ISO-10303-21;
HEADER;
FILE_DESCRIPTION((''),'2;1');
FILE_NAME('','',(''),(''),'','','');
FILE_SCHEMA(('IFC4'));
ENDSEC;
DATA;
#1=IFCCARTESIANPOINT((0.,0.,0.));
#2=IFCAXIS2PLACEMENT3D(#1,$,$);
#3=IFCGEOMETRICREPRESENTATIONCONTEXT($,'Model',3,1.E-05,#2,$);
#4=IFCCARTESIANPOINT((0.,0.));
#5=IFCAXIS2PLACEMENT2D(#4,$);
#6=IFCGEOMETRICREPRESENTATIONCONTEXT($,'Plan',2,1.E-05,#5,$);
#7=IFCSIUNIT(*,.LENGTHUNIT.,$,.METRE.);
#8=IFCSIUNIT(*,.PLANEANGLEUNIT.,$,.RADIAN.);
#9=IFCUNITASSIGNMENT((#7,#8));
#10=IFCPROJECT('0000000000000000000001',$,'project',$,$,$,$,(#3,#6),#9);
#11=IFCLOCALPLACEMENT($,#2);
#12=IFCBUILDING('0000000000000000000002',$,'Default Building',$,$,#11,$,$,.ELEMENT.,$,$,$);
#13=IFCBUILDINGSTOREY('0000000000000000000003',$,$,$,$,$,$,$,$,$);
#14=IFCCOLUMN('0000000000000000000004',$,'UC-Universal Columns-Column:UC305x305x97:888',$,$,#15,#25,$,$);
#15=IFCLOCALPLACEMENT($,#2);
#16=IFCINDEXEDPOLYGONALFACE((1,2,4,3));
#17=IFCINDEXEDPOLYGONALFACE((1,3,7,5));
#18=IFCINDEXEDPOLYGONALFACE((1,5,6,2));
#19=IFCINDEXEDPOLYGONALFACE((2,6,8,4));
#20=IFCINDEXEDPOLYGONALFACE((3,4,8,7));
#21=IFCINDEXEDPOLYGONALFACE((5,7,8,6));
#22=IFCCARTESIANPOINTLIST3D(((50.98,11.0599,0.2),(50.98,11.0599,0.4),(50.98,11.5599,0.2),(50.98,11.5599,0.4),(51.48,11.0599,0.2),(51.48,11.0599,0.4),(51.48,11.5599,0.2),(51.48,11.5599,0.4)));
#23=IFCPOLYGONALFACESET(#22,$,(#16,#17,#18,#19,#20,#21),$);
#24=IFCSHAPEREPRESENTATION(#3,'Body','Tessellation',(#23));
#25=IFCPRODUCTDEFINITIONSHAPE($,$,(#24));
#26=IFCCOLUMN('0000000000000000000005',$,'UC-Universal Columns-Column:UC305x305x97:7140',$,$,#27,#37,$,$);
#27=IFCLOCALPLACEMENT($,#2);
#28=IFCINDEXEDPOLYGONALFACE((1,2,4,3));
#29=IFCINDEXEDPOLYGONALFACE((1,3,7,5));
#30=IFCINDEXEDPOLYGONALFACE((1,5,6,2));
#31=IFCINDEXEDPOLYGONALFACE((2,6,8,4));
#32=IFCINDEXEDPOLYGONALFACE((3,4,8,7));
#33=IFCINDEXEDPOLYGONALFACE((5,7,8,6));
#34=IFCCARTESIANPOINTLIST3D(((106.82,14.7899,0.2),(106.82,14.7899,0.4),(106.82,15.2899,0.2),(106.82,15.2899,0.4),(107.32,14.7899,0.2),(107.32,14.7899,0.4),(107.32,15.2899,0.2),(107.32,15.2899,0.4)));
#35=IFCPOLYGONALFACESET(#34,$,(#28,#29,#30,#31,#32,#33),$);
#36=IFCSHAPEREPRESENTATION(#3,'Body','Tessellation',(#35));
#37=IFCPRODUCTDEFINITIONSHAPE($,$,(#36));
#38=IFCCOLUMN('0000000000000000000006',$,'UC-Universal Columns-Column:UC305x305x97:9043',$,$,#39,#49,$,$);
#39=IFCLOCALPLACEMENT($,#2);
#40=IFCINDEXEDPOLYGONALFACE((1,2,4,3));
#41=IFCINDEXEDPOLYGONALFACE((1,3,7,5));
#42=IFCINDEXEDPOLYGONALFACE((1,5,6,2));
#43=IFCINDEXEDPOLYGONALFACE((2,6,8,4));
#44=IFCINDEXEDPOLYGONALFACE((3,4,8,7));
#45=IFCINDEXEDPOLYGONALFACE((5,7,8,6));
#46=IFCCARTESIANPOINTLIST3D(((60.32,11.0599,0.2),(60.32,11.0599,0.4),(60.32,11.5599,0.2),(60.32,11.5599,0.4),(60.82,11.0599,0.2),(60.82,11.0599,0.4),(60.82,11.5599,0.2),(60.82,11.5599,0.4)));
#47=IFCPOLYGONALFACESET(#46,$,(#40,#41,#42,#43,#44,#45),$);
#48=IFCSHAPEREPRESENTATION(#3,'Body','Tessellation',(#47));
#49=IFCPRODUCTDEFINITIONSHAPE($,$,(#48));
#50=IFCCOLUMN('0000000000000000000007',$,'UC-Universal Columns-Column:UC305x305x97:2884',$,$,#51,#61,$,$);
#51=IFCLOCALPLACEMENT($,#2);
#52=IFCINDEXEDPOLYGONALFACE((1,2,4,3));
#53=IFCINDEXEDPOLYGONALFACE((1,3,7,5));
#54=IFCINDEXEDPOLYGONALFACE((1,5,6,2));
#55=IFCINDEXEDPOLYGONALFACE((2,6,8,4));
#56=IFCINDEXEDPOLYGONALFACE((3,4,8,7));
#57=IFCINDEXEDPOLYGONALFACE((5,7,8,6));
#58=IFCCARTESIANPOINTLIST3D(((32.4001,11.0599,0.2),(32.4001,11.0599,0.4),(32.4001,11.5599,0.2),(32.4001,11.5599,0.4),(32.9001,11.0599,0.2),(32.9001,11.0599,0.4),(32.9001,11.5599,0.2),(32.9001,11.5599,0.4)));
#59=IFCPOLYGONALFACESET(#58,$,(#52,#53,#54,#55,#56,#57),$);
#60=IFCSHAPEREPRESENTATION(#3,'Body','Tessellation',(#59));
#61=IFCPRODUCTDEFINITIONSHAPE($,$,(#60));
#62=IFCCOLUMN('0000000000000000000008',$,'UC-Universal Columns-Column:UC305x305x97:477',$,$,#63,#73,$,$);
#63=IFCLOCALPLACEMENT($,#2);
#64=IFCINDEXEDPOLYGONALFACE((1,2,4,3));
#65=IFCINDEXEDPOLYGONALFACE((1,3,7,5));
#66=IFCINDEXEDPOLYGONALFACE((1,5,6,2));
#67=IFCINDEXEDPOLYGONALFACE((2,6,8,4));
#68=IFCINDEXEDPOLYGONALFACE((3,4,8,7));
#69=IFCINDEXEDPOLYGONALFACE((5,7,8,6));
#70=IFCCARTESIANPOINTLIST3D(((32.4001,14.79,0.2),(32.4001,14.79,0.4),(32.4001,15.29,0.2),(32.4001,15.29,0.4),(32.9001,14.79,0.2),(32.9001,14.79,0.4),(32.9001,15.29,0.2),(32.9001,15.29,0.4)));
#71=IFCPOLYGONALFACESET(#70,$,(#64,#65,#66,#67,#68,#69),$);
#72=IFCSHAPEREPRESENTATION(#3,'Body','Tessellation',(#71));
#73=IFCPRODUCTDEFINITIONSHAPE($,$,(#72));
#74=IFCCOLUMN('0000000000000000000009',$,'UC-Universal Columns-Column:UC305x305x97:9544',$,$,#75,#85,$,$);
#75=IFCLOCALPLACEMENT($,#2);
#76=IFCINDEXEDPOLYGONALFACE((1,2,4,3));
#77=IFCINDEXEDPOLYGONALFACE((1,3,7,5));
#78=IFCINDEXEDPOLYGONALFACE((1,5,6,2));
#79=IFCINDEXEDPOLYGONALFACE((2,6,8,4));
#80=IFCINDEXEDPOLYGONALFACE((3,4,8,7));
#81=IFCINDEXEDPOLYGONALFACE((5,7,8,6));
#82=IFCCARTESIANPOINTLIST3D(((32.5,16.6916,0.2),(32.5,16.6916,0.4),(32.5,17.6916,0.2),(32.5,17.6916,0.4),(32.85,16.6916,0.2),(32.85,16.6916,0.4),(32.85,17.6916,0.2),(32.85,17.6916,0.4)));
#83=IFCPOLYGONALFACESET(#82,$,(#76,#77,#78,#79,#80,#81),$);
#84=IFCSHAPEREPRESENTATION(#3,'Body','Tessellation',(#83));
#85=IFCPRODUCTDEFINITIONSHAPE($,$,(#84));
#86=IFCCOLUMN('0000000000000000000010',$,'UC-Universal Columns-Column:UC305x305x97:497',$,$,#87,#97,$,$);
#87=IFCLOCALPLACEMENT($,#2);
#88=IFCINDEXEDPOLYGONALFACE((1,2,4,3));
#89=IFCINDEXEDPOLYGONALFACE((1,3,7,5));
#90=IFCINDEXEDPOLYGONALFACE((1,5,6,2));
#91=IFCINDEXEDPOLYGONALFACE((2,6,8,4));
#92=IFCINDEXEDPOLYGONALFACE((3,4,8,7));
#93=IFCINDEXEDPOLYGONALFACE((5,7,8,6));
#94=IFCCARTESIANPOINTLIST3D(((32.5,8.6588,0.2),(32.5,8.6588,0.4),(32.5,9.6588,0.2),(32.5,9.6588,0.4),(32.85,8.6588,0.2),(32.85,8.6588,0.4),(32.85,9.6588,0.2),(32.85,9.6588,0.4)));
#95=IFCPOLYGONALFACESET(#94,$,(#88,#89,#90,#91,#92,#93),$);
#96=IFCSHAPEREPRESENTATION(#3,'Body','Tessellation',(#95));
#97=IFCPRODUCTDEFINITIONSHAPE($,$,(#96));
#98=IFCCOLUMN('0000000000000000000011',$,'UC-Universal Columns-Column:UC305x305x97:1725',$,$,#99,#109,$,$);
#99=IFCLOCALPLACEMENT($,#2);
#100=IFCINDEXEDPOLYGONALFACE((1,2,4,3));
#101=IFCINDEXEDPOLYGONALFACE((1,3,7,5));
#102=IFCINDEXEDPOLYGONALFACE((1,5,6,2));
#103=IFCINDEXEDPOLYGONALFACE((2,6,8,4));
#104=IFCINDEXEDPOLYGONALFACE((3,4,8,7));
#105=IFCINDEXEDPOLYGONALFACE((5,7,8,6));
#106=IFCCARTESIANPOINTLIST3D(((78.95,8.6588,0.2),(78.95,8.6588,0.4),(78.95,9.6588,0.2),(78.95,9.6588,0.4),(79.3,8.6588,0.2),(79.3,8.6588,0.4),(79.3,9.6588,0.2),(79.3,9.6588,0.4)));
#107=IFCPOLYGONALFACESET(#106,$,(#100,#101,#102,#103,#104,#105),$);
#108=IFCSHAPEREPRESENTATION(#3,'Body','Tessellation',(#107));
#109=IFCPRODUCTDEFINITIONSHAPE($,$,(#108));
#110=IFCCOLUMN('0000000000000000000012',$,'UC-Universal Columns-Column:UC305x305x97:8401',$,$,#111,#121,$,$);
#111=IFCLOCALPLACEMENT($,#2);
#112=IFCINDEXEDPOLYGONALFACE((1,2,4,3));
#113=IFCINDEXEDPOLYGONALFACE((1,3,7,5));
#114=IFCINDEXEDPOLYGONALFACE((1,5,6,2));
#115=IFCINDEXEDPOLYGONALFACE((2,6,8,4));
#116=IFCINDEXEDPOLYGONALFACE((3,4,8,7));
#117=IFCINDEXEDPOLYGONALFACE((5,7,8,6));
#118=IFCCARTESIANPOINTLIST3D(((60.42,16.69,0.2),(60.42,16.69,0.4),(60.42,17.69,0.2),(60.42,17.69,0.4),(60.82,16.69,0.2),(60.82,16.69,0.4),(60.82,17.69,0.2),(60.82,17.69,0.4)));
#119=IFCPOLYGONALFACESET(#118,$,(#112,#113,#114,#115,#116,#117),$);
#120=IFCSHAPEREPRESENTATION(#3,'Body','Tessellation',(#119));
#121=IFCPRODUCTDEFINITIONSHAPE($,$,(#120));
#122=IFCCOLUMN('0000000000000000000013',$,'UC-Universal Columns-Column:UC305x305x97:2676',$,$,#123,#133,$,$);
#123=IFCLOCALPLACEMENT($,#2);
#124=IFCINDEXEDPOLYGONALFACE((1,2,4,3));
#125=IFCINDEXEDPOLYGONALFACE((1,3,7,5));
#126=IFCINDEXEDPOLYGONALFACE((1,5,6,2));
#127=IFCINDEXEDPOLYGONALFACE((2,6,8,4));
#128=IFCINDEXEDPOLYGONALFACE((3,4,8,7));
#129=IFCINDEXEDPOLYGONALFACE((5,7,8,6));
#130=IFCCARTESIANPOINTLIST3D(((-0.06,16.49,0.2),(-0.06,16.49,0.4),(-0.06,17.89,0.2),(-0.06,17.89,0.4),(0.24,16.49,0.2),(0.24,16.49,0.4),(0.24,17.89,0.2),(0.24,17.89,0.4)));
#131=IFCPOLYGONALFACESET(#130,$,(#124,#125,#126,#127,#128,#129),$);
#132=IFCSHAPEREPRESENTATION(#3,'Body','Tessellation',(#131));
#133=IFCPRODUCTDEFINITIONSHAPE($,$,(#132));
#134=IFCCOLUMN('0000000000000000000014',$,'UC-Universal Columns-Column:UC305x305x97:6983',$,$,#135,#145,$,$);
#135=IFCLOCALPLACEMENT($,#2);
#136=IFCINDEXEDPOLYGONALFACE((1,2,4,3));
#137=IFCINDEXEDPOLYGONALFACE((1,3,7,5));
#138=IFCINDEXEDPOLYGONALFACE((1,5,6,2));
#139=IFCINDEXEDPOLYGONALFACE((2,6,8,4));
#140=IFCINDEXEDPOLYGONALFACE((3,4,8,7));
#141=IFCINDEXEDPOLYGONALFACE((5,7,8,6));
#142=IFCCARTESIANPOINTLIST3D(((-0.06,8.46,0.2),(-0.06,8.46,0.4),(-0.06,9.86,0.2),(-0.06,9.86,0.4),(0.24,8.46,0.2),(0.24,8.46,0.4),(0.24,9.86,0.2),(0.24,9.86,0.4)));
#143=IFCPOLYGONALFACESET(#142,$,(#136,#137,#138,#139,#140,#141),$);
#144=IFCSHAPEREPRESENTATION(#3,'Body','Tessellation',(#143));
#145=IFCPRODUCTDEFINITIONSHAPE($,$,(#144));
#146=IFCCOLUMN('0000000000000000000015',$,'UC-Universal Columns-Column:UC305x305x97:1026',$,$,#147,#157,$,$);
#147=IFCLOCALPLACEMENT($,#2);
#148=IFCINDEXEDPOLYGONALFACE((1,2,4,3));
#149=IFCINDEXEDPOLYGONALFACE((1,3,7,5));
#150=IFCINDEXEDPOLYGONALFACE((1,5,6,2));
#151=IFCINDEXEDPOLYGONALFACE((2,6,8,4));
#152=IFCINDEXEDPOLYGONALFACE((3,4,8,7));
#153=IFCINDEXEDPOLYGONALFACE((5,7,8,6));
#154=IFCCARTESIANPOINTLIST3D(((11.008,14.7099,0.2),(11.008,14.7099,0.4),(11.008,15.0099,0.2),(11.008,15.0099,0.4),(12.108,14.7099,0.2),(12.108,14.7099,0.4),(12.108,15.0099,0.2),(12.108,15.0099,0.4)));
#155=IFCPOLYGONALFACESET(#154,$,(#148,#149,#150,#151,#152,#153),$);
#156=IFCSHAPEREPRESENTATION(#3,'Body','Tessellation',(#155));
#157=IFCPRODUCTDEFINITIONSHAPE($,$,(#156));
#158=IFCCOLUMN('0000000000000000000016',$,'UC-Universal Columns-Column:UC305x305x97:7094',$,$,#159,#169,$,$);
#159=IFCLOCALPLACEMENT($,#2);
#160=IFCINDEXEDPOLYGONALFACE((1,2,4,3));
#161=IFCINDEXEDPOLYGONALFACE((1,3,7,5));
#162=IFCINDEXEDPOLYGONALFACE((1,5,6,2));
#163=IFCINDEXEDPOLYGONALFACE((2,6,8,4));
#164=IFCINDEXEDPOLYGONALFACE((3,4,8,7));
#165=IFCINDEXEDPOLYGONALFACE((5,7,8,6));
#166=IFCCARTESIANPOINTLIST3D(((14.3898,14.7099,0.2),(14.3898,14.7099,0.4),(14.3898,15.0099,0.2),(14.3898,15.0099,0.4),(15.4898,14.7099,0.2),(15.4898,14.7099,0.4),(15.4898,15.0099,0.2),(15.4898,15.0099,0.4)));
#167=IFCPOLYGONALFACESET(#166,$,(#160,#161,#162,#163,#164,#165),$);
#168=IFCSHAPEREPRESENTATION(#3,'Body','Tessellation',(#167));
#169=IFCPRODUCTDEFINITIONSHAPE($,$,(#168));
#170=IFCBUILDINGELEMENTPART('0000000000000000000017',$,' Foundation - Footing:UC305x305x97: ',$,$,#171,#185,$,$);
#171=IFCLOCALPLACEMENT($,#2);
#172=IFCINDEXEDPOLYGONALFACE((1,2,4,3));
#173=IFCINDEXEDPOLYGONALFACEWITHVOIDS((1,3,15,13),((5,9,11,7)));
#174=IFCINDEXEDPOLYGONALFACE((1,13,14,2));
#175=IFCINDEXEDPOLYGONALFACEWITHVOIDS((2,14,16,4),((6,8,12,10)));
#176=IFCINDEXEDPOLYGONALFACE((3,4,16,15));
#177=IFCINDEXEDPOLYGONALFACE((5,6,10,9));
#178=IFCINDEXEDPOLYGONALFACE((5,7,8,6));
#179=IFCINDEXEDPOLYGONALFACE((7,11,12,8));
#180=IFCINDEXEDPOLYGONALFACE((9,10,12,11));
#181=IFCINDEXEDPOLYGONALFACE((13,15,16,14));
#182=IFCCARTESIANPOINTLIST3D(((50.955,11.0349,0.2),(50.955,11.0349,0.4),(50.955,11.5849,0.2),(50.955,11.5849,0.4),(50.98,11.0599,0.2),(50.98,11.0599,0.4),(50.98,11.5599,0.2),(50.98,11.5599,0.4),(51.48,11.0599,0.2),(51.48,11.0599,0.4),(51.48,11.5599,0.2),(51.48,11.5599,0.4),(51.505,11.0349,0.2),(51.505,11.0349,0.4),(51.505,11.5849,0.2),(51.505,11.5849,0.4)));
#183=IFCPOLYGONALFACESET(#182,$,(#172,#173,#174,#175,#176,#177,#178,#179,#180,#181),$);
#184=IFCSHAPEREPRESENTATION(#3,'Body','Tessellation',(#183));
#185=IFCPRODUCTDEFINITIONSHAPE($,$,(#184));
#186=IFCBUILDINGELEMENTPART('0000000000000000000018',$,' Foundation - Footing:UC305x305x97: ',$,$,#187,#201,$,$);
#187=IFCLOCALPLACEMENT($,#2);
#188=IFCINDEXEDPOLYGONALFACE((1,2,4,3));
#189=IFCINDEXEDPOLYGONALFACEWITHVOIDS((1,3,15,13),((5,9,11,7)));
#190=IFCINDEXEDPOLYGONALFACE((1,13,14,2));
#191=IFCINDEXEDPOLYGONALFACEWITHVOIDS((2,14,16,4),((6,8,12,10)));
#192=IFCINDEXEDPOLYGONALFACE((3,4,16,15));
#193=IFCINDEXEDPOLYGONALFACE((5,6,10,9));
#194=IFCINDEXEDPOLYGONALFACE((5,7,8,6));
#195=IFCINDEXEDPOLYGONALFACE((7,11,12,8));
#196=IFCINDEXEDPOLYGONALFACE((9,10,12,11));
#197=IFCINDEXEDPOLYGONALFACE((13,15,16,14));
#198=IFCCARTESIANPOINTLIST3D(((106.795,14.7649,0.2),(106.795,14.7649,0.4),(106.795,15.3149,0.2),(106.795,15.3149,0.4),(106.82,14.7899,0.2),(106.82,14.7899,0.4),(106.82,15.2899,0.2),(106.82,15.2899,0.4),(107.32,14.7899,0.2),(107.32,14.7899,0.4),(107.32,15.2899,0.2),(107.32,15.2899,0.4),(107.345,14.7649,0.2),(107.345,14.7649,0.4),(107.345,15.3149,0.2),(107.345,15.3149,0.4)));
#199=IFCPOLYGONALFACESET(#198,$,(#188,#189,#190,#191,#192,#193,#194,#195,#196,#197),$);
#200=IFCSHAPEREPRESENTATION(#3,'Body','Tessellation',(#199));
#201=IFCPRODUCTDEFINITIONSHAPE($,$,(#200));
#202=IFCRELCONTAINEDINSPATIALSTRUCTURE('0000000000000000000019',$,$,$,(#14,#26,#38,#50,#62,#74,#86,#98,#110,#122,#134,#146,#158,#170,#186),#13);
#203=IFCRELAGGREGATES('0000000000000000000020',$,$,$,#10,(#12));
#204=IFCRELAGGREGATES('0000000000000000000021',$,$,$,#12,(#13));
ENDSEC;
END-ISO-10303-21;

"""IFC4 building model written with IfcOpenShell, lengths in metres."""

from ifc_helpers import new_model, si_unit, origin, origin_2d, place, context, project, spatial, polyline, outline, extrude, element, save


model = new_model("IFC4")

# Units and contexts
model_context = context("Model", 3, precision=1e-05, world=origin())
plan_context = context("Plan", 2, precision=1e-05, world=origin_2d())
ifc_project = project(units=[si_unit("LENGTHUNIT", "METRE"), si_unit("PLANEANGLEUNIT", "RADIAN")], contexts=[model_context, plan_context])

# Building, storey
building_placement = place(None, origin())
building = spatial("IfcBuilding", under=ifc_project, at=building_placement, Name="Default Building", CompositionType="ELEMENT")
storey = spatial("IfcBuildingStorey", under=building)

# Columns
element("IfcColumn", 1, inside=storey, Name="UC-Universal Columns-Column:UC305x305x97:888", context=model_context, shape_type="SweptSolid", body=[
    extrude(outline(polyline([(50.98, 11.0599, 0.2), (51.48, 11.0599, 0.2), (51.48, 11.5599, 0.2), (50.98, 11.5599, 0.2), (50.98, 11.0599, 0.2)])), None, (0.0, 0.0, 1.0), 0.2),
])
element("IfcColumn", 2, inside=storey, Name="UC-Universal Columns-Column:UC305x305x97:7140", context=model_context, shape_type="SweptSolid", body=[
    extrude(outline(polyline([(106.82, 15.2899, 0.2), (107.32, 15.2899, 0.2), (107.32, 14.7899, 0.2), (106.82, 14.7899, 0.2), (106.82, 15.2899, 0.2)])), None, (0.0, 0.0, 1.0), 0.2),
])
element("IfcColumn", 3, inside=storey, Name="UC-Universal Columns-Column:UC305x305x97:9043", context=model_context, shape_type="SweptSolid", body=[
    extrude(outline(polyline([(60.82, 11.0599, 0.2), (60.32, 11.0599, 0.2), (60.32, 11.5599, 0.2), (60.82, 11.5599, 0.2), (60.82, 11.0599, 0.2)])), None, (0.0, 0.0, 1.0), 0.2),
])
element("IfcColumn", 4, inside=storey, Name="UC-Universal Columns-Column:UC305x305x97:2884", context=model_context, shape_type="SweptSolid", body=[
    extrude(outline(polyline([(32.9001, 11.0599, 0.2), (32.4001, 11.0599, 0.2), (32.4001, 11.5599, 0.2), (32.9001, 11.5599, 0.2), (32.9001, 11.0599, 0.2)])), None, (0.0, 0.0, 1.0), 0.2),
])
element("IfcColumn", 5, inside=storey, Name="UC-Universal Columns-Column:UC305x305x97:477", context=model_context, shape_type="SweptSolid", body=[
    extrude(outline(polyline([(32.9001, 15.29, 0.2), (32.4001, 15.29, 0.2), (32.4001, 14.79, 0.2), (32.9001, 14.79, 0.2), (32.9001, 15.29, 0.2)])), None, (0.0, 0.0, 1.0), 0.2),
])
element("IfcColumn", 6, inside=storey, Name="UC-Universal Columns-Column:UC305x305x97:9544", context=model_context, shape_type="SweptSolid", body=[
    extrude(outline(polyline([(32.5, 17.6916, 0.2), (32.85, 17.6916, 0.2), (32.85, 16.6916, 0.2), (32.5, 16.6916, 0.2), (32.5, 17.6916, 0.2)])), None, (0.0, 0.0, 1.0), 0.2),
])
element("IfcColumn", 7, inside=storey, Name="UC-Universal Columns-Column:UC305x305x97:497", context=model_context, shape_type="SweptSolid", body=[
    extrude(outline(polyline([(32.5, 8.6588, 0.2), (32.85, 8.6588, 0.2), (32.85, 9.6588, 0.2), (32.5, 9.6588, 0.2), (32.5, 8.6588, 0.2)])), None, (0.0, 0.0, 1.0), 0.2),
])
element("IfcColumn", 8, inside=storey, Name="UC-Universal Columns-Column:UC305x305x97:1725", context=model_context, shape_type="SweptSolid", body=[
    extrude(outline(polyline([(79.3, 8.6588, 0.2), (78.95, 8.6588, 0.2), (78.95, 9.6588, 0.2), (79.3, 9.6588, 0.2), (79.3, 8.6588, 0.2)])), None, (0.0, 0.0, 1.0), 0.2),
])
element("IfcColumn", 9, inside=storey, Name="UC-Universal Columns-Column:UC305x305x97:8401", context=model_context, shape_type="SweptSolid", body=[
    extrude(outline(polyline([(60.42, 17.69, 0.2), (60.82, 17.69, 0.2), (60.82, 16.69, 0.2), (60.42, 16.69, 0.2), (60.42, 17.69, 0.2)])), None, (0.0, 0.0, 1.0), 0.2),
])
element("IfcColumn", 10, inside=storey, Name="UC-Universal Columns-Column:UC305x305x97:2676", context=model_context, shape_type="SweptSolid", body=[
    extrude(outline(polyline([(-0.06, 17.89, 0.2), (0.24, 17.89, 0.2), (0.24, 16.49, 0.2), (-0.06, 16.49, 0.2), (-0.06, 17.89, 0.2)])), None, (0.0, 0.0, 1.0), 0.2),
])
element("IfcColumn", 11, inside=storey, Name="UC-Universal Columns-Column:UC305x305x97:6983", context=model_context, shape_type="SweptSolid", body=[
    extrude(outline(polyline([(-0.06, 8.46, 0.2), (0.24, 8.46, 0.2), (0.24, 9.86, 0.2), (-0.06, 9.86, 0.2), (-0.06, 8.46, 0.2)])), None, (0.0, 0.0, 1.0), 0.2),
])
element("IfcColumn", 12, inside=storey, Name="UC-Universal Columns-Column:UC305x305x97:1026", context=model_context, shape_type="SweptSolid", body=[
    extrude(outline(polyline([(11.008, 14.7099, 0.2), (11.008, 15.0099, 0.2), (12.108, 15.0099, 0.2), (12.108, 14.7099, 0.2), (11.008, 14.7099, 0.2)])), None, (0.0, 0.0, 1.0), 0.2),
])
element("IfcColumn", 13, inside=storey, Name="UC-Universal Columns-Column:UC305x305x97:7094", context=model_context, shape_type="SweptSolid", body=[
    extrude(outline(polyline([(14.3898, 15.0099, 0.2), (15.4898, 15.0099, 0.2), (15.4898, 14.7099, 0.2), (14.3898, 14.7099, 0.2), (14.3898, 15.0099, 0.2)])), None, (0.0, 0.0, 1.0), 0.2),
])

# Building element parts, openings
building_element_part_1 = element("IfcBuildingElementPart", 14, inside=storey, Name=" Foundation - Footing:UC305x305x97: ", context=model_context, shape_type="SweptSolid", body=[
    extrude(outline(polyline([(50.955, 11.0349, 0.2), (51.505, 11.0349, 0.2), (51.505, 11.5849, 0.2), (50.955, 11.5849, 0.2), (50.955, 11.0349, 0.2)])), None, (0.0, 0.0, 1.0), 0.2),
])
element("IfcOpeningElement", 15, inside=storey, cuts=building_element_part_1, context=model_context, shape_type="SweptSolid", body=[
    extrude(outline(polyline([(50.98, 11.0599, 0.2), (51.48, 11.0599, 0.2), (51.48, 11.5599, 0.2), (50.98, 11.5599, 0.2), (50.98, 11.0599, 0.2)])), None, (0.0, 0.0, 1.0), 0.2),
])
building_element_part_2 = element("IfcBuildingElementPart", 16, inside=storey, Name=" Foundation - Footing:UC305x305x97: ", context=model_context, shape_type="SweptSolid", body=[
    extrude(outline(polyline([(106.795, 15.3149, 0.2), (107.345, 15.3149, 0.2), (107.345, 14.7649, 0.2), (106.795, 14.7649, 0.2), (106.795, 15.3149, 0.2)])), None, (0.0, 0.0, 1.0), 0.2),
])
element("IfcOpeningElement", 17, inside=storey, cuts=building_element_part_2, context=model_context, shape_type="SweptSolid", body=[
    extrude(outline(polyline([(106.82, 15.2899, 0.2), (107.32, 15.2899, 0.2), (107.32, 14.7899, 0.2), (106.82, 14.7899, 0.2), (106.82, 15.2899, 0.2)])), None, (0.0, 0.0, 1.0), 0.2),
])

save(model, "model.ifc")
